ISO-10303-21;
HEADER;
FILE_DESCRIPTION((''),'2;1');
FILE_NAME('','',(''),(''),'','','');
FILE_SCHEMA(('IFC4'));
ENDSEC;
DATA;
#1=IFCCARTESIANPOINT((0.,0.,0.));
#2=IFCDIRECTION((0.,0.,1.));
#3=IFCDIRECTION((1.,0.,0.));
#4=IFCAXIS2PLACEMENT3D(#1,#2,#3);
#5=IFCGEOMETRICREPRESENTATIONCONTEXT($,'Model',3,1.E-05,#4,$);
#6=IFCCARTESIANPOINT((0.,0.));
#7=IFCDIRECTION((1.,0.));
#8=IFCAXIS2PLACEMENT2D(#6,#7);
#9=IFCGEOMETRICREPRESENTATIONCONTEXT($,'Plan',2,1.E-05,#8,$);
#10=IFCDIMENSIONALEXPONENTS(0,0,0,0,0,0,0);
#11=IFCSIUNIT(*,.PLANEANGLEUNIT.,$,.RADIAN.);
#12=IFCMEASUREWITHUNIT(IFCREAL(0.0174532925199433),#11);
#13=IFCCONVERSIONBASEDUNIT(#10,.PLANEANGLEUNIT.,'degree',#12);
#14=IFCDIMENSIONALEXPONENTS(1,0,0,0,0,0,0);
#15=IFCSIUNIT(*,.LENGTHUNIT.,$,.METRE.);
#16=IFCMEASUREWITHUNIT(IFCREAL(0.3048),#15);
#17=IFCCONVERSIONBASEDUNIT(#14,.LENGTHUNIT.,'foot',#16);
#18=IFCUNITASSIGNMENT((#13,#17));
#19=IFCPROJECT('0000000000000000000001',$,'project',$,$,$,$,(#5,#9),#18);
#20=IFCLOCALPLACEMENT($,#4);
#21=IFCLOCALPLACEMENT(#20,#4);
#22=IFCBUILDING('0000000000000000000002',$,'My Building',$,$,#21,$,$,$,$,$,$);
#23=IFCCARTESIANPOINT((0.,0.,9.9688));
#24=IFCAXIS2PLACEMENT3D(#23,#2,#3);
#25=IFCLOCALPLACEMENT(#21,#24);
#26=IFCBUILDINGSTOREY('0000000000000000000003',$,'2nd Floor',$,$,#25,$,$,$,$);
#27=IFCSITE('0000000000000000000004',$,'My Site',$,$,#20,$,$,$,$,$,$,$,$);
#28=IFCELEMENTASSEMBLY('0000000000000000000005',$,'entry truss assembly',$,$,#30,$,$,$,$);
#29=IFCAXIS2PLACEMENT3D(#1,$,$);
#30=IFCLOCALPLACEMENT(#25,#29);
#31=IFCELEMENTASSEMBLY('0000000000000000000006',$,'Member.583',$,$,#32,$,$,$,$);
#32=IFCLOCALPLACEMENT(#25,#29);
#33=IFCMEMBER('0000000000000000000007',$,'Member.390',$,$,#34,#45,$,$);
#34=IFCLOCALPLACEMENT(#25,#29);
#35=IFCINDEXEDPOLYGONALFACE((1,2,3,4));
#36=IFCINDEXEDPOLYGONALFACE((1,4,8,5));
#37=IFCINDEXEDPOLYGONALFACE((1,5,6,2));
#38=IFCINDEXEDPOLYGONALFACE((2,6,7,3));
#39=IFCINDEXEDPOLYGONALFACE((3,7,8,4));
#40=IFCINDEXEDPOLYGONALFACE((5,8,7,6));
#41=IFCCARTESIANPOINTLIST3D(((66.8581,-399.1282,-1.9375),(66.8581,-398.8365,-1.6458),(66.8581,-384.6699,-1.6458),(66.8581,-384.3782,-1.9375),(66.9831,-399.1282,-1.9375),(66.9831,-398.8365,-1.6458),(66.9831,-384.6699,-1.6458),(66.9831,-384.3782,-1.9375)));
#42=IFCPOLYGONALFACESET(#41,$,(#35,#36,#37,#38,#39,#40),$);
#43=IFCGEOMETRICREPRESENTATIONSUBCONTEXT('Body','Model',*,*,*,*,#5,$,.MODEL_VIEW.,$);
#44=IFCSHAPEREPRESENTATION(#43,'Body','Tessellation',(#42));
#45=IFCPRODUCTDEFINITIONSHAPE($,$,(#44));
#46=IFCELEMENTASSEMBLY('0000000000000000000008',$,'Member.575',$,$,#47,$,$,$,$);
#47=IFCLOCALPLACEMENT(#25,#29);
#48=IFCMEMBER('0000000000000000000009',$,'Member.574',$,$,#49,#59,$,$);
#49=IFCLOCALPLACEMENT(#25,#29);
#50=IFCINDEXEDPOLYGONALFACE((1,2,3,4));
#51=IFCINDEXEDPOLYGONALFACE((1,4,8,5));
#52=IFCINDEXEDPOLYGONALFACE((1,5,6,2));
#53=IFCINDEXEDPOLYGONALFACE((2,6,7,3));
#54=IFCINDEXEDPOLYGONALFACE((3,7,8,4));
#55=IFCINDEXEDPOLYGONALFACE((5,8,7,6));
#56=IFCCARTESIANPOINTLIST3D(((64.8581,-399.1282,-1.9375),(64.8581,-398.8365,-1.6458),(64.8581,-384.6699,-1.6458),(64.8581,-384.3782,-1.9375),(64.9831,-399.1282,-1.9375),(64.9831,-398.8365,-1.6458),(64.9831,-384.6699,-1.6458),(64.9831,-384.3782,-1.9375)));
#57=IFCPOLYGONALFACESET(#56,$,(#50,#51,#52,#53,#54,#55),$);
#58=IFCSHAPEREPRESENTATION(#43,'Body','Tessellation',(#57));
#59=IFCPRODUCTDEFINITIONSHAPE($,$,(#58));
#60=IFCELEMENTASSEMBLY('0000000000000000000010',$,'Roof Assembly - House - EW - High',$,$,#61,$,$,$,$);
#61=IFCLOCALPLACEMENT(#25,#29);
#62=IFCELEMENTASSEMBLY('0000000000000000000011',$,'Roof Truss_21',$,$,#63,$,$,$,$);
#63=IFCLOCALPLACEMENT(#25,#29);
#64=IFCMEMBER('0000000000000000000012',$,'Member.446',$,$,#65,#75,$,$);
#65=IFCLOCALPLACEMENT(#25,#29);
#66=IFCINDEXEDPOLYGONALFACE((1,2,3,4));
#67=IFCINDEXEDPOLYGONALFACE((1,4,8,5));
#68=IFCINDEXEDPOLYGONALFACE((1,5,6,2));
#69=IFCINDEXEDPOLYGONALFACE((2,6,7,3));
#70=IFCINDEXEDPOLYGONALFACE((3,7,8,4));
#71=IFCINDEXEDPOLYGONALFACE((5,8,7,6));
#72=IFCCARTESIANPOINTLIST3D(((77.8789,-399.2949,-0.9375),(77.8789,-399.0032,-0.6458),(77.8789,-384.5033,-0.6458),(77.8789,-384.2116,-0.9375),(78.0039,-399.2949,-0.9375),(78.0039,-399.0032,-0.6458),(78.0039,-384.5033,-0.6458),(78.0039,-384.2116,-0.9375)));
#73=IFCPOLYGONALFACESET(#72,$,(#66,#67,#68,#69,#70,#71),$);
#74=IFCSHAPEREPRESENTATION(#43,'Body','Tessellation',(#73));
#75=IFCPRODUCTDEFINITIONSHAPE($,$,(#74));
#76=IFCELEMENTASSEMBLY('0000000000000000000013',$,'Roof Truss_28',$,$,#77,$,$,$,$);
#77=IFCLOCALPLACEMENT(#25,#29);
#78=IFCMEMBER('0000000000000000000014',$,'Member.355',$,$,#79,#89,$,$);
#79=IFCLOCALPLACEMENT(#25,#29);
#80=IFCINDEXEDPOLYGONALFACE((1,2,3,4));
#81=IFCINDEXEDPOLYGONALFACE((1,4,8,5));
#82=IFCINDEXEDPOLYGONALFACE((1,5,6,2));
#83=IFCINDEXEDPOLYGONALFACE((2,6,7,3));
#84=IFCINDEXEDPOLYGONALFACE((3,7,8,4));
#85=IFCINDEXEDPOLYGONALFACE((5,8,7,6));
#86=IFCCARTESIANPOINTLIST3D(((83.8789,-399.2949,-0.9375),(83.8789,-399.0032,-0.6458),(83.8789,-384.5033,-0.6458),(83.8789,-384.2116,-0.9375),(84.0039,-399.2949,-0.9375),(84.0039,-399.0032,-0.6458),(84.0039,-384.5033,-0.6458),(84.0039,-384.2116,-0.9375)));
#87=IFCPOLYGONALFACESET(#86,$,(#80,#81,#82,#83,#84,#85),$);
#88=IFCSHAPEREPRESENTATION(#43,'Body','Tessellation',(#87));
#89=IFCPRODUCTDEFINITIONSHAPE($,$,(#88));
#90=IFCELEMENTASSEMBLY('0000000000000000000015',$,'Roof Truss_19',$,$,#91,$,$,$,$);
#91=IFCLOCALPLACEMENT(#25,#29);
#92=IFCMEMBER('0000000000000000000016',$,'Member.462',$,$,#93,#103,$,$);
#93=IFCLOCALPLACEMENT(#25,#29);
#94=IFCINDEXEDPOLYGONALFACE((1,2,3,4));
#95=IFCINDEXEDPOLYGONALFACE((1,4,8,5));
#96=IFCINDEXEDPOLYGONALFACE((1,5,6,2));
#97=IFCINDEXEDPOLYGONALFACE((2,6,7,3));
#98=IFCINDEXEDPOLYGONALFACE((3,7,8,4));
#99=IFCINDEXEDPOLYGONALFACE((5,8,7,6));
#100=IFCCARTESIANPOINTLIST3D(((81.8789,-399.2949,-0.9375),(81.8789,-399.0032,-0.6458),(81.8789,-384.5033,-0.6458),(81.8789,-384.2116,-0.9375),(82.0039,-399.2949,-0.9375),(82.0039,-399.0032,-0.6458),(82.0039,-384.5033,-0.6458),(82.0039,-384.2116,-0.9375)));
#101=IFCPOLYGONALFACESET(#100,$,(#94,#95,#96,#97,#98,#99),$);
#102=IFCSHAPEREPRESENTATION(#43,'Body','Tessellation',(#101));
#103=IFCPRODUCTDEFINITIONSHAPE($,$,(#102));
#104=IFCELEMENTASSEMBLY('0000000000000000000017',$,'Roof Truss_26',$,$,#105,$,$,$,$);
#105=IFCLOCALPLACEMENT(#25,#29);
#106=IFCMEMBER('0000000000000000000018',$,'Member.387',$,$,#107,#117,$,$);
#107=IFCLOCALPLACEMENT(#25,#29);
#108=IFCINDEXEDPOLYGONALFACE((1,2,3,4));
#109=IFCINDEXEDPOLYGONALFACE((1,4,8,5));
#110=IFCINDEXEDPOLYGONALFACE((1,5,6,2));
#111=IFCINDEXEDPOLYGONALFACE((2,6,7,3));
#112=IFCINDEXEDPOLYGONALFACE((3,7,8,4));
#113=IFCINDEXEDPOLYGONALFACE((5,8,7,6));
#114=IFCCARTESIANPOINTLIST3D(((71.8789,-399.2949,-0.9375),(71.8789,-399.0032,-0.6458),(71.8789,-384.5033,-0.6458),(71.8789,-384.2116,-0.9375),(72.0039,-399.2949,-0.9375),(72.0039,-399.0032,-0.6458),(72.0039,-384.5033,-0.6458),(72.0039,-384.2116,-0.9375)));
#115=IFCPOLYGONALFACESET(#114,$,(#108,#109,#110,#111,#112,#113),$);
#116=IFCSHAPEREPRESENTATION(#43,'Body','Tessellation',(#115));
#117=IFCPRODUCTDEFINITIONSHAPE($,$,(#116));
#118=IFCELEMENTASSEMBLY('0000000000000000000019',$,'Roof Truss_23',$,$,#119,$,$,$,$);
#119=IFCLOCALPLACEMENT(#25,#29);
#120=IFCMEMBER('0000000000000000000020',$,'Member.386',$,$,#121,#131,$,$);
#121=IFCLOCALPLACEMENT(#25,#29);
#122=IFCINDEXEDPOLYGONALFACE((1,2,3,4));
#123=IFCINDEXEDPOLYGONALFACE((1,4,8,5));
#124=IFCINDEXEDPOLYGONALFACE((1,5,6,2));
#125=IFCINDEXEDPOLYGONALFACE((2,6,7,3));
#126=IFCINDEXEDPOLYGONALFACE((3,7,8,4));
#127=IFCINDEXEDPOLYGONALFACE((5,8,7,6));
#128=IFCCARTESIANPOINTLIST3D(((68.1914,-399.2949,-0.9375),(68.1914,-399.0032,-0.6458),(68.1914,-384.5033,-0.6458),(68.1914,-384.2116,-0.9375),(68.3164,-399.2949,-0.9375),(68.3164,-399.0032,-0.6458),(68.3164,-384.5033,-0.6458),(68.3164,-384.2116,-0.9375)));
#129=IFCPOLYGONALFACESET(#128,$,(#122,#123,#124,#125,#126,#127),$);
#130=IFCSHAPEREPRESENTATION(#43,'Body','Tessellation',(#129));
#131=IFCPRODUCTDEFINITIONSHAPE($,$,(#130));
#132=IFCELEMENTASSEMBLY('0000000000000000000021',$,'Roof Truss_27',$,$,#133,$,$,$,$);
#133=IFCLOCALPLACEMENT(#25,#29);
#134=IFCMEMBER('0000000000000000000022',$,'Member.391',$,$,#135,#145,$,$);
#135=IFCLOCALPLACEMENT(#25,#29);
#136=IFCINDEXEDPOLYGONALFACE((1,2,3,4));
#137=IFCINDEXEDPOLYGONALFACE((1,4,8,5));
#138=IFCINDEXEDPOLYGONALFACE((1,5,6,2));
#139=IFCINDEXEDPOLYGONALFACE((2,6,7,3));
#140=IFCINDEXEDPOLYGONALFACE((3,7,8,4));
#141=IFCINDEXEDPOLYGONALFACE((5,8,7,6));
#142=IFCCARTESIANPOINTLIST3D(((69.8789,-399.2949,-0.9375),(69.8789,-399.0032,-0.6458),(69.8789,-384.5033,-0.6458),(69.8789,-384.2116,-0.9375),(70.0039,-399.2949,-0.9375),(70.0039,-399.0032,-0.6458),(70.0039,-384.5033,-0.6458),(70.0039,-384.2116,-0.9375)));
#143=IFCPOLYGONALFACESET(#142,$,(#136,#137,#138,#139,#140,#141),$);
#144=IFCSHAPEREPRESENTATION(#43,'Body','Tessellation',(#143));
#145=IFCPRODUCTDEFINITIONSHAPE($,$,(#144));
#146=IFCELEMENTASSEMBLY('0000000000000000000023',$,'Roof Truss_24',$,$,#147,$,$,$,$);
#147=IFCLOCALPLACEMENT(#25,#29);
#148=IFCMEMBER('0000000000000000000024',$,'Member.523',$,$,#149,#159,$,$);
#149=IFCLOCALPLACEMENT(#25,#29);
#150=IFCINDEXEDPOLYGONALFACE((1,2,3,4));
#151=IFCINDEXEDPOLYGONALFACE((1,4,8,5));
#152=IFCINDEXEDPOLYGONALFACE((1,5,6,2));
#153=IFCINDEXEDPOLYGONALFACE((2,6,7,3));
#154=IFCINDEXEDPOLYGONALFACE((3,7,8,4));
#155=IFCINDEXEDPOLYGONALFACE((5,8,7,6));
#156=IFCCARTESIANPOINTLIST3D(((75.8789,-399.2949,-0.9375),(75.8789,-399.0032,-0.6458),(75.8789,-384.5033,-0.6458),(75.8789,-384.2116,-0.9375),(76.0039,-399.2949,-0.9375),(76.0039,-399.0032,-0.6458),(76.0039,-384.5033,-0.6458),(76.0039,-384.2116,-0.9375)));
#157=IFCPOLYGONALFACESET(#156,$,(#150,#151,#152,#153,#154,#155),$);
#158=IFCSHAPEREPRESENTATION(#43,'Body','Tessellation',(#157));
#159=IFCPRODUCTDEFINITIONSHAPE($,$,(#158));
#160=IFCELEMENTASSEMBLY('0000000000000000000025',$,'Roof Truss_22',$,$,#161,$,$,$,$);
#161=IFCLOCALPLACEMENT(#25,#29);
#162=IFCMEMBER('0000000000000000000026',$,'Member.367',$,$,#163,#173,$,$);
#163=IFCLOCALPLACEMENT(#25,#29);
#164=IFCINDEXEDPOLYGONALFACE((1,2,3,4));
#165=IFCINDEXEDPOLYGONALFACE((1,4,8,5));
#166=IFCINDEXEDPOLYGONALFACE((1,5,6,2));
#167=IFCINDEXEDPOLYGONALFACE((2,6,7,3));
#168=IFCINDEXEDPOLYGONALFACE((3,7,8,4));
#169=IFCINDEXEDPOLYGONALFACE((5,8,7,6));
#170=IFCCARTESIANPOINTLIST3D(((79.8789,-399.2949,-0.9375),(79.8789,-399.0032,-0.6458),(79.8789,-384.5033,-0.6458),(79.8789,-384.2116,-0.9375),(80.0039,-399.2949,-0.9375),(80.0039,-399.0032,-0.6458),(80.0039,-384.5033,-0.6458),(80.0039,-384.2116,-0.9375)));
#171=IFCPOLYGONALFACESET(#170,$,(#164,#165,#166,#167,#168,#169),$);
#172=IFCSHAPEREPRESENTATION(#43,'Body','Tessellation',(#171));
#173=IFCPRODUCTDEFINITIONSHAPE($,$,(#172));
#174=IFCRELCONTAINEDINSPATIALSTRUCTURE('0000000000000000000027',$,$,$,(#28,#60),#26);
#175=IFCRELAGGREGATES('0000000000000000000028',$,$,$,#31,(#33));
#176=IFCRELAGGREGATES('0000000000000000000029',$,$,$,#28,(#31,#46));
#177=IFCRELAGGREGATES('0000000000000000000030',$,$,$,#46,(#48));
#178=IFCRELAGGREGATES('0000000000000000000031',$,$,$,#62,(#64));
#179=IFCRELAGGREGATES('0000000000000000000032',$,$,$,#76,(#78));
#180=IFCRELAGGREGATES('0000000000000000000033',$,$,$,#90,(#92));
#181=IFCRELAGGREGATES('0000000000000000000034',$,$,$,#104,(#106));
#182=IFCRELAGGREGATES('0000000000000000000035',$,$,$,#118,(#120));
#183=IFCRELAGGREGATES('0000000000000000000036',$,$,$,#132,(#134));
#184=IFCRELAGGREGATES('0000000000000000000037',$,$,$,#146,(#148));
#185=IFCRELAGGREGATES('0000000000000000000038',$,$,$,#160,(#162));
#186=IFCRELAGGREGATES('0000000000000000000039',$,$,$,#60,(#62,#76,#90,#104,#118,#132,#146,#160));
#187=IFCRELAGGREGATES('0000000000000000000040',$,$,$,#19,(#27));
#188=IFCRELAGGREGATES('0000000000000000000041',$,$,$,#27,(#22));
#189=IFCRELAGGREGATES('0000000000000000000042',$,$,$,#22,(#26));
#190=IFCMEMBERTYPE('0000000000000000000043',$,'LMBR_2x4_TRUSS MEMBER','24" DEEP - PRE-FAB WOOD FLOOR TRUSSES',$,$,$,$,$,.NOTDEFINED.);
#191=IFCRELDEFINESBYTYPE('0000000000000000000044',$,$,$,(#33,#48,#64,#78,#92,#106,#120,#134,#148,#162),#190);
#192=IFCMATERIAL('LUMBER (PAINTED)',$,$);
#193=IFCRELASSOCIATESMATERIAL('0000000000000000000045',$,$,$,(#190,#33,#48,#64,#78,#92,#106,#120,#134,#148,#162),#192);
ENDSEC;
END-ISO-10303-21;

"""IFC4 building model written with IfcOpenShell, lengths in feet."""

from ifc_helpers import new_model, entity, si_unit, converted_unit, frame, origin_with_axes, origin_2d_with_axis, place, context, subcontext, project, spatial, indexed_curve, outline, extrude, clip, halfspace, material, material_profile, profile_set, profile_usage, type_object, element, aggregate, save


model = new_model("IFC4")

# Units and contexts
model_context = context("Model", 3, precision=1e-05, world=origin_with_axes())
plan_context = context("Plan", 2, precision=1e-05, world=origin_2d_with_axis())
body_context = subcontext(model_context, "Body", "Model", "MODEL_VIEW")
ifc_project = project(units=[converted_unit("PLANEANGLEUNIT", "degree", entity("IfcReal", 0.0174532925199433), si_unit("PLANEANGLEUNIT", "RADIAN"), dimensions=[0, 0, 0, 0, 0, 0, 0]), converted_unit("LENGTHUNIT", "foot", entity("IfcReal", 0.3048), si_unit("LENGTHUNIT", "METRE"), dimensions=[1, 0, 0, 0, 0, 0, 0])], contexts=[model_context, plan_context])

# Site, building, storey
site_placement = place(None, origin_with_axes())
site = spatial("IfcSite", under=ifc_project, at=site_placement, Name="My Site")
building_placement = place(site_placement, origin_with_axes())
building = spatial("IfcBuilding", under=site, at=building_placement, Name="My Building")
storey_placement = place(building_placement, frame((0.0, 0.0, 9.9688), z_axis=(0.0, 0.0, 1.0), x_axis=(1.0, 0.0, 0.0)))
storey = spatial("IfcBuildingStorey", under=building, at=storey_placement, Name="2nd Floor")

# Element assemblies, members
assembly_1_placement = place(storey_placement, frame((63.6176, -384.3782, -1.9062), z_axis=(0.0, 0.0, 1.0), x_axis=(1.0, 0.0, 0.0)))
assembly_1 = element("IfcElementAssembly", 1, at=assembly_1_placement, inside=storey, Name="entry truss assembly")
assembly_2_placement = place(assembly_1_placement, frame((3.303, -7.375, 3.4566), z_axis=(0.0, 0.0, 1.0), x_axis=(1.0, 0.0, 0.0)))
assembly_2 = element("IfcElementAssembly", 2, at=assembly_2_placement, Name="Member.583")
ifc_material_1 = material(Name="LUMBER (PAINTED)")
ifc_material_profile_1 = material_profile(ifc_material_1, outline(indexed_curve([(-0.0625, -0.1458), (0.0625, -0.1458), (0.0625, 0.1458), (-0.0625, 0.1458), (-0.0625, -0.1458)])))
ifc_profile_set_1 = profile_set([ifc_material_profile_1])
member_type_1 = type_object("IfcMemberType", Name="LMBR_2x4_TRUSS MEMBER", Description="24\" DEEP - PRE-FAB WOOD FLOOR TRUSSES", PredefinedType="NOTDEFINED", material=ifc_profile_set_1)
ifc_profile_usage_1 = profile_usage(ifc_profile_set_1)
member_1_placement = place(assembly_2_placement, frame((0.0, 7.375, -3.3421), z_axis=(0.0, -1.0, 0.0), x_axis=(-1.0, 0.0, 0.0)))
member_1 = element("IfcMember", 3, at=member_1_placement, type_object=member_type_1, material=ifc_profile_usage_1, Name="Member.390", context=body_context, shape_type="Clipping", body=[
    clip(clip(extrude(outline(indexed_curve([(-0.0625, -0.1458), (0.0625, -0.1458), (0.0625, 0.1458), (-0.0625, 0.1458), (-0.0625, -0.1458)])), origin_with_axes(), (0.0, 0.0, 1.0), 14.7499), halfspace(frame((66.9205, 0.1458, 0.0), z_axis=(0.0, -0.707097, -0.707116), x_axis=(-1.0, 0.0, 0.0)), False)), halfspace(frame((66.9206, 0.1458, 14.7499), z_axis=(0.0, -0.707097, 0.707116), x_axis=(-1.0, 0.0, 0.0)), False)),
])
aggregate(assembly_2, [member_1])
assembly_3_placement = place(assembly_1_placement, frame((1.303, -7.375, 3.4566), z_axis=(0.0, 0.0, 1.0), x_axis=(1.0, 0.0, 0.0)))
assembly_3 = element("IfcElementAssembly", 4, at=assembly_3_placement, Name="Member.575")
aggregate(assembly_1, [assembly_2, assembly_3])
ifc_profile_usage_2 = profile_usage(ifc_profile_set_1)
member_2_placement = place(assembly_3_placement, frame((0.0, 7.375, -3.3421), z_axis=(0.0, -1.0, 0.0), x_axis=(-1.0, 0.0, 0.0)))
member_2 = element("IfcMember", 5, at=member_2_placement, type_object=member_type_1, material=ifc_profile_usage_2, Name="Member.574", context=body_context, shape_type="Clipping", body=[
    clip(clip(extrude(outline(indexed_curve([(-0.0625, -0.1458), (0.0625, -0.1458), (0.0625, 0.1458), (-0.0625, 0.1458), (-0.0625, -0.1458)])), origin_with_axes(), (0.0, 0.0, 1.0), 14.7499), halfspace(frame((66.9205, 0.1458, 0.0), z_axis=(0.0, -0.707097, -0.707116), x_axis=(-1.0, 0.0, 0.0)), False)), halfspace(frame((66.9206, 0.1458, 14.7499), z_axis=(0.0, -0.707097, 0.707116), x_axis=(-1.0, 0.0, 0.0)), False)),
])
aggregate(assembly_3, [member_2])
assembly_4_placement = place(storey_placement, frame((0.0, 0.0, -9.9063), z_axis=(0.0, 0.0, 1.0), x_axis=(1.0, 0.0, 0.0)))
assembly_4 = element("IfcElementAssembly", 6, at=assembly_4_placement, inside=storey, Name="Roof Assembly - House - EW - High")
assembly_5_placement = place(assembly_4_placement, frame((77.9414, -391.7532, 12.5192), z_axis=(0.0, 0.0, 1.0), x_axis=(0.0, 1.0, 0.0)))
assembly_5 = element("IfcElementAssembly", 7, at=assembly_5_placement, Name="Roof Truss_21")
ifc_profile_usage_3 = profile_usage(ifc_profile_set_1)
member_3_placement = place(assembly_5_placement, frame((7.5416, 0.0, -3.4046), z_axis=(-1.0, 0.0, 0.0), x_axis=(0.0, 1.0, 0.0)))
member_3 = element("IfcMember", 8, at=member_3_placement, type_object=member_type_1, material=ifc_profile_usage_3, Name="Member.446", context=body_context, shape_type="Clipping", body=[
    clip(clip(extrude(outline(indexed_curve([(-0.0625, -0.1458), (0.0625, -0.1458), (0.0625, 0.1458), (-0.0625, 0.1458), (-0.0625, -0.1458)])), origin_with_axes(), (0.0, 0.0, 1.0), 15.0833), halfspace(frame((397.5032, 0.1458, 0.0001), z_axis=(0.0, -0.707114, -0.707099), x_axis=(-1.0, 0.0, 0.0)), False)), halfspace(frame((397.5032, 0.1458, 15.0832), z_axis=(0.0, -0.707107, 0.707107), x_axis=(-1.0, 0.0, 0.0)), False)),
])
aggregate(assembly_5, [member_3])
assembly_6_placement = place(assembly_4_placement, frame((83.9414, -391.7532, 12.5192), z_axis=(0.0, 0.0, 1.0), x_axis=(0.0, 1.0, 0.0)))
assembly_6 = element("IfcElementAssembly", 9, at=assembly_6_placement, Name="Roof Truss_28")
ifc_profile_usage_4 = profile_usage(ifc_profile_set_1)
member_4_placement = place(assembly_6_placement, frame((7.5416, 0.0, -3.4046), z_axis=(-1.0, 0.0, 0.0), x_axis=(0.0, 1.0, 0.0)))
member_4 = element("IfcMember", 10, at=member_4_placement, type_object=member_type_1, material=ifc_profile_usage_4, Name="Member.355", context=body_context, shape_type="Clipping", body=[
    clip(clip(extrude(outline(indexed_curve([(-0.0625, -0.1458), (0.0625, -0.1458), (0.0625, 0.1458), (-0.0625, 0.1458), (-0.0625, -0.1458)])), origin_with_axes(), (0.0, 0.0, 1.0), 15.0833), halfspace(frame((397.5032, 0.1458, 0.0001), z_axis=(0.0, -0.707114, -0.707099), x_axis=(-1.0, 0.0, 0.0)), False)), halfspace(frame((397.5032, 0.1458, 15.0832), z_axis=(0.0, -0.707107, 0.707107), x_axis=(-1.0, 0.0, 0.0)), False)),
])
aggregate(assembly_6, [member_4])
assembly_7_placement = place(assembly_4_placement, frame((81.9414, -391.7532, 12.5192), z_axis=(0.0, 0.0, 1.0), x_axis=(0.0, 1.0, 0.0)))
assembly_7 = element("IfcElementAssembly", 11, at=assembly_7_placement, Name="Roof Truss_19")
ifc_profile_usage_5 = profile_usage(ifc_profile_set_1)
member_5_placement = place(assembly_7_placement, frame((7.5416, 0.0, -3.4046), z_axis=(-1.0, 0.0, 0.0), x_axis=(0.0, 1.0, 0.0)))
member_5 = element("IfcMember", 12, at=member_5_placement, type_object=member_type_1, material=ifc_profile_usage_5, Name="Member.462", context=body_context, shape_type="Clipping", body=[
    clip(clip(extrude(outline(indexed_curve([(-0.0625, -0.1458), (0.0625, -0.1458), (0.0625, 0.1458), (-0.0625, 0.1458), (-0.0625, -0.1458)])), origin_with_axes(), (0.0, 0.0, 1.0), 15.0833), halfspace(frame((397.5032, 0.1458, 0.0001), z_axis=(0.0, -0.707114, -0.707099), x_axis=(-1.0, 0.0, 0.0)), False)), halfspace(frame((397.5032, 0.1458, 15.0832), z_axis=(0.0, -0.707107, 0.707107), x_axis=(-1.0, 0.0, 0.0)), False)),
])
aggregate(assembly_7, [member_5])
assembly_8_placement = place(assembly_4_placement, frame((71.9414, -391.7532, 12.5192), z_axis=(0.0, 0.0, 1.0), x_axis=(0.0, 1.0, 0.0)))
assembly_8 = element("IfcElementAssembly", 13, at=assembly_8_placement, Name="Roof Truss_26")
ifc_profile_usage_6 = profile_usage(ifc_profile_set_1)
member_6_placement = place(assembly_8_placement, frame((7.5416, 0.0, -3.4046), z_axis=(-1.0, 0.0, 0.0), x_axis=(0.0, 1.0, 0.0)))
member_6 = element("IfcMember", 14, at=member_6_placement, type_object=member_type_1, material=ifc_profile_usage_6, Name="Member.387", context=body_context, shape_type="Clipping", body=[
    clip(clip(extrude(outline(indexed_curve([(-0.0625, -0.1458), (0.0625, -0.1458), (0.0625, 0.1458), (-0.0625, 0.1458), (-0.0625, -0.1458)])), origin_with_axes(), (0.0, 0.0, 1.0), 15.0833), halfspace(frame((397.5032, 0.1458, 0.0001), z_axis=(0.0, -0.707114, -0.707099), x_axis=(-1.0, 0.0, 0.0)), False)), halfspace(frame((397.5032, 0.1458, 15.0832), z_axis=(0.0, -0.707107, 0.707107), x_axis=(-1.0, 0.0, 0.0)), False)),
])
aggregate(assembly_8, [member_6])
assembly_9_placement = place(assembly_4_placement, frame((68.2539, -391.7532, 12.5192), z_axis=(0.0, 0.0, 1.0), x_axis=(0.0, 1.0, 0.0)))
assembly_9 = element("IfcElementAssembly", 15, at=assembly_9_placement, Name="Roof Truss_23")
ifc_profile_usage_7 = profile_usage(ifc_profile_set_1)
member_7_placement = place(assembly_9_placement, frame((7.5416, 0.0, -3.4046), z_axis=(-1.0, 0.0, 0.0), x_axis=(0.0, 1.0, 0.0)))
member_7 = element("IfcMember", 16, at=member_7_placement, type_object=member_type_1, material=ifc_profile_usage_7, Name="Member.386", context=body_context, shape_type="Clipping", body=[
    clip(clip(extrude(outline(indexed_curve([(-0.0625, -0.1458), (0.0625, -0.1458), (0.0625, 0.1458), (-0.0625, 0.1458), (-0.0625, -0.1458)])), origin_with_axes(), (0.0, 0.0, 1.0), 15.0833), halfspace(frame((397.5032, 0.1458, 0.0001), z_axis=(0.0, -0.707114, -0.707099), x_axis=(-1.0, 0.0, 0.0)), False)), halfspace(frame((397.5032, 0.1458, 15.0832), z_axis=(0.0, -0.707107, 0.707107), x_axis=(-1.0, 0.0, 0.0)), False)),
])
aggregate(assembly_9, [member_7])
assembly_10_placement = place(assembly_4_placement, frame((69.9414, -391.7532, 12.5192), z_axis=(0.0, 0.0, 1.0), x_axis=(0.0, 1.0, 0.0)))
assembly_10 = element("IfcElementAssembly", 17, at=assembly_10_placement, Name="Roof Truss_27")
ifc_profile_usage_8 = profile_usage(ifc_profile_set_1)
member_8_placement = place(assembly_10_placement, frame((7.5416, 0.0, -3.4046), z_axis=(-1.0, 0.0, 0.0), x_axis=(0.0, 1.0, 0.0)))
member_8 = element("IfcMember", 18, at=member_8_placement, type_object=member_type_1, material=ifc_profile_usage_8, Name="Member.391", context=body_context, shape_type="Clipping", body=[
    clip(clip(extrude(outline(indexed_curve([(-0.0625, -0.1458), (0.0625, -0.1458), (0.0625, 0.1458), (-0.0625, 0.1458), (-0.0625, -0.1458)])), origin_with_axes(), (0.0, 0.0, 1.0), 15.0833), halfspace(frame((397.5032, 0.1458, 0.0001), z_axis=(0.0, -0.707114, -0.707099), x_axis=(-1.0, 0.0, 0.0)), False)), halfspace(frame((397.5032, 0.1458, 15.0832), z_axis=(0.0, -0.707107, 0.707107), x_axis=(-1.0, 0.0, 0.0)), False)),
])
aggregate(assembly_10, [member_8])
assembly_11_placement = place(assembly_4_placement, frame((75.9414, -391.7532, 12.5192), z_axis=(0.0, 0.0, 1.0), x_axis=(0.0, 1.0, 0.0)))
assembly_11 = element("IfcElementAssembly", 19, at=assembly_11_placement, Name="Roof Truss_24")
ifc_profile_usage_9 = profile_usage(ifc_profile_set_1)
member_9_placement = place(assembly_11_placement, frame((7.5416, 0.0, -3.4046), z_axis=(-1.0, 0.0, 0.0), x_axis=(0.0, 1.0, 0.0)))
member_9 = element("IfcMember", 20, at=member_9_placement, type_object=member_type_1, material=ifc_profile_usage_9, Name="Member.523", context=body_context, shape_type="Clipping", body=[
    clip(clip(extrude(outline(indexed_curve([(-0.0625, -0.1458), (0.0625, -0.1458), (0.0625, 0.1458), (-0.0625, 0.1458), (-0.0625, -0.1458)])), origin_with_axes(), (0.0, 0.0, 1.0), 15.0833), halfspace(frame((397.5032, 0.1458, 0.0001), z_axis=(0.0, -0.707114, -0.707099), x_axis=(-1.0, 0.0, 0.0)), False)), halfspace(frame((397.5032, 0.1458, 15.0832), z_axis=(0.0, -0.707107, 0.707107), x_axis=(-1.0, 0.0, 0.0)), False)),
])
aggregate(assembly_11, [member_9])
assembly_12_placement = place(assembly_4_placement, frame((79.9414, -391.7532, 12.5192), z_axis=(0.0, 0.0, 1.0), x_axis=(0.0, 1.0, 0.0)))
assembly_12 = element("IfcElementAssembly", 21, at=assembly_12_placement, Name="Roof Truss_22")
ifc_profile_usage_10 = profile_usage(ifc_profile_set_1)
member_10_placement = place(assembly_12_placement, frame((7.5416, 0.0, -3.4046), z_axis=(-1.0, 0.0, 0.0), x_axis=(0.0, 1.0, 0.0)))
member_10 = element("IfcMember", 22, at=member_10_placement, type_object=member_type_1, material=ifc_profile_usage_10, Name="Member.367", context=body_context, shape_type="Clipping", body=[
    clip(clip(extrude(outline(indexed_curve([(-0.0625, -0.1458), (0.0625, -0.1458), (0.0625, 0.1458), (-0.0625, 0.1458), (-0.0625, -0.1458)])), origin_with_axes(), (0.0, 0.0, 1.0), 15.0833), halfspace(frame((397.5032, 0.1458, 0.0001), z_axis=(0.0, -0.707114, -0.707099), x_axis=(-1.0, 0.0, 0.0)), False)), halfspace(frame((397.5032, 0.1458, 15.0832), z_axis=(0.0, -0.707107, 0.707107), x_axis=(-1.0, 0.0, 0.0)), False)),
])
aggregate(assembly_12, [member_10])

aggregate(assembly_4, [assembly_5, assembly_6, assembly_7, assembly_8, assembly_9, assembly_10, assembly_11, assembly_12])

save(model, "model.ifc")
